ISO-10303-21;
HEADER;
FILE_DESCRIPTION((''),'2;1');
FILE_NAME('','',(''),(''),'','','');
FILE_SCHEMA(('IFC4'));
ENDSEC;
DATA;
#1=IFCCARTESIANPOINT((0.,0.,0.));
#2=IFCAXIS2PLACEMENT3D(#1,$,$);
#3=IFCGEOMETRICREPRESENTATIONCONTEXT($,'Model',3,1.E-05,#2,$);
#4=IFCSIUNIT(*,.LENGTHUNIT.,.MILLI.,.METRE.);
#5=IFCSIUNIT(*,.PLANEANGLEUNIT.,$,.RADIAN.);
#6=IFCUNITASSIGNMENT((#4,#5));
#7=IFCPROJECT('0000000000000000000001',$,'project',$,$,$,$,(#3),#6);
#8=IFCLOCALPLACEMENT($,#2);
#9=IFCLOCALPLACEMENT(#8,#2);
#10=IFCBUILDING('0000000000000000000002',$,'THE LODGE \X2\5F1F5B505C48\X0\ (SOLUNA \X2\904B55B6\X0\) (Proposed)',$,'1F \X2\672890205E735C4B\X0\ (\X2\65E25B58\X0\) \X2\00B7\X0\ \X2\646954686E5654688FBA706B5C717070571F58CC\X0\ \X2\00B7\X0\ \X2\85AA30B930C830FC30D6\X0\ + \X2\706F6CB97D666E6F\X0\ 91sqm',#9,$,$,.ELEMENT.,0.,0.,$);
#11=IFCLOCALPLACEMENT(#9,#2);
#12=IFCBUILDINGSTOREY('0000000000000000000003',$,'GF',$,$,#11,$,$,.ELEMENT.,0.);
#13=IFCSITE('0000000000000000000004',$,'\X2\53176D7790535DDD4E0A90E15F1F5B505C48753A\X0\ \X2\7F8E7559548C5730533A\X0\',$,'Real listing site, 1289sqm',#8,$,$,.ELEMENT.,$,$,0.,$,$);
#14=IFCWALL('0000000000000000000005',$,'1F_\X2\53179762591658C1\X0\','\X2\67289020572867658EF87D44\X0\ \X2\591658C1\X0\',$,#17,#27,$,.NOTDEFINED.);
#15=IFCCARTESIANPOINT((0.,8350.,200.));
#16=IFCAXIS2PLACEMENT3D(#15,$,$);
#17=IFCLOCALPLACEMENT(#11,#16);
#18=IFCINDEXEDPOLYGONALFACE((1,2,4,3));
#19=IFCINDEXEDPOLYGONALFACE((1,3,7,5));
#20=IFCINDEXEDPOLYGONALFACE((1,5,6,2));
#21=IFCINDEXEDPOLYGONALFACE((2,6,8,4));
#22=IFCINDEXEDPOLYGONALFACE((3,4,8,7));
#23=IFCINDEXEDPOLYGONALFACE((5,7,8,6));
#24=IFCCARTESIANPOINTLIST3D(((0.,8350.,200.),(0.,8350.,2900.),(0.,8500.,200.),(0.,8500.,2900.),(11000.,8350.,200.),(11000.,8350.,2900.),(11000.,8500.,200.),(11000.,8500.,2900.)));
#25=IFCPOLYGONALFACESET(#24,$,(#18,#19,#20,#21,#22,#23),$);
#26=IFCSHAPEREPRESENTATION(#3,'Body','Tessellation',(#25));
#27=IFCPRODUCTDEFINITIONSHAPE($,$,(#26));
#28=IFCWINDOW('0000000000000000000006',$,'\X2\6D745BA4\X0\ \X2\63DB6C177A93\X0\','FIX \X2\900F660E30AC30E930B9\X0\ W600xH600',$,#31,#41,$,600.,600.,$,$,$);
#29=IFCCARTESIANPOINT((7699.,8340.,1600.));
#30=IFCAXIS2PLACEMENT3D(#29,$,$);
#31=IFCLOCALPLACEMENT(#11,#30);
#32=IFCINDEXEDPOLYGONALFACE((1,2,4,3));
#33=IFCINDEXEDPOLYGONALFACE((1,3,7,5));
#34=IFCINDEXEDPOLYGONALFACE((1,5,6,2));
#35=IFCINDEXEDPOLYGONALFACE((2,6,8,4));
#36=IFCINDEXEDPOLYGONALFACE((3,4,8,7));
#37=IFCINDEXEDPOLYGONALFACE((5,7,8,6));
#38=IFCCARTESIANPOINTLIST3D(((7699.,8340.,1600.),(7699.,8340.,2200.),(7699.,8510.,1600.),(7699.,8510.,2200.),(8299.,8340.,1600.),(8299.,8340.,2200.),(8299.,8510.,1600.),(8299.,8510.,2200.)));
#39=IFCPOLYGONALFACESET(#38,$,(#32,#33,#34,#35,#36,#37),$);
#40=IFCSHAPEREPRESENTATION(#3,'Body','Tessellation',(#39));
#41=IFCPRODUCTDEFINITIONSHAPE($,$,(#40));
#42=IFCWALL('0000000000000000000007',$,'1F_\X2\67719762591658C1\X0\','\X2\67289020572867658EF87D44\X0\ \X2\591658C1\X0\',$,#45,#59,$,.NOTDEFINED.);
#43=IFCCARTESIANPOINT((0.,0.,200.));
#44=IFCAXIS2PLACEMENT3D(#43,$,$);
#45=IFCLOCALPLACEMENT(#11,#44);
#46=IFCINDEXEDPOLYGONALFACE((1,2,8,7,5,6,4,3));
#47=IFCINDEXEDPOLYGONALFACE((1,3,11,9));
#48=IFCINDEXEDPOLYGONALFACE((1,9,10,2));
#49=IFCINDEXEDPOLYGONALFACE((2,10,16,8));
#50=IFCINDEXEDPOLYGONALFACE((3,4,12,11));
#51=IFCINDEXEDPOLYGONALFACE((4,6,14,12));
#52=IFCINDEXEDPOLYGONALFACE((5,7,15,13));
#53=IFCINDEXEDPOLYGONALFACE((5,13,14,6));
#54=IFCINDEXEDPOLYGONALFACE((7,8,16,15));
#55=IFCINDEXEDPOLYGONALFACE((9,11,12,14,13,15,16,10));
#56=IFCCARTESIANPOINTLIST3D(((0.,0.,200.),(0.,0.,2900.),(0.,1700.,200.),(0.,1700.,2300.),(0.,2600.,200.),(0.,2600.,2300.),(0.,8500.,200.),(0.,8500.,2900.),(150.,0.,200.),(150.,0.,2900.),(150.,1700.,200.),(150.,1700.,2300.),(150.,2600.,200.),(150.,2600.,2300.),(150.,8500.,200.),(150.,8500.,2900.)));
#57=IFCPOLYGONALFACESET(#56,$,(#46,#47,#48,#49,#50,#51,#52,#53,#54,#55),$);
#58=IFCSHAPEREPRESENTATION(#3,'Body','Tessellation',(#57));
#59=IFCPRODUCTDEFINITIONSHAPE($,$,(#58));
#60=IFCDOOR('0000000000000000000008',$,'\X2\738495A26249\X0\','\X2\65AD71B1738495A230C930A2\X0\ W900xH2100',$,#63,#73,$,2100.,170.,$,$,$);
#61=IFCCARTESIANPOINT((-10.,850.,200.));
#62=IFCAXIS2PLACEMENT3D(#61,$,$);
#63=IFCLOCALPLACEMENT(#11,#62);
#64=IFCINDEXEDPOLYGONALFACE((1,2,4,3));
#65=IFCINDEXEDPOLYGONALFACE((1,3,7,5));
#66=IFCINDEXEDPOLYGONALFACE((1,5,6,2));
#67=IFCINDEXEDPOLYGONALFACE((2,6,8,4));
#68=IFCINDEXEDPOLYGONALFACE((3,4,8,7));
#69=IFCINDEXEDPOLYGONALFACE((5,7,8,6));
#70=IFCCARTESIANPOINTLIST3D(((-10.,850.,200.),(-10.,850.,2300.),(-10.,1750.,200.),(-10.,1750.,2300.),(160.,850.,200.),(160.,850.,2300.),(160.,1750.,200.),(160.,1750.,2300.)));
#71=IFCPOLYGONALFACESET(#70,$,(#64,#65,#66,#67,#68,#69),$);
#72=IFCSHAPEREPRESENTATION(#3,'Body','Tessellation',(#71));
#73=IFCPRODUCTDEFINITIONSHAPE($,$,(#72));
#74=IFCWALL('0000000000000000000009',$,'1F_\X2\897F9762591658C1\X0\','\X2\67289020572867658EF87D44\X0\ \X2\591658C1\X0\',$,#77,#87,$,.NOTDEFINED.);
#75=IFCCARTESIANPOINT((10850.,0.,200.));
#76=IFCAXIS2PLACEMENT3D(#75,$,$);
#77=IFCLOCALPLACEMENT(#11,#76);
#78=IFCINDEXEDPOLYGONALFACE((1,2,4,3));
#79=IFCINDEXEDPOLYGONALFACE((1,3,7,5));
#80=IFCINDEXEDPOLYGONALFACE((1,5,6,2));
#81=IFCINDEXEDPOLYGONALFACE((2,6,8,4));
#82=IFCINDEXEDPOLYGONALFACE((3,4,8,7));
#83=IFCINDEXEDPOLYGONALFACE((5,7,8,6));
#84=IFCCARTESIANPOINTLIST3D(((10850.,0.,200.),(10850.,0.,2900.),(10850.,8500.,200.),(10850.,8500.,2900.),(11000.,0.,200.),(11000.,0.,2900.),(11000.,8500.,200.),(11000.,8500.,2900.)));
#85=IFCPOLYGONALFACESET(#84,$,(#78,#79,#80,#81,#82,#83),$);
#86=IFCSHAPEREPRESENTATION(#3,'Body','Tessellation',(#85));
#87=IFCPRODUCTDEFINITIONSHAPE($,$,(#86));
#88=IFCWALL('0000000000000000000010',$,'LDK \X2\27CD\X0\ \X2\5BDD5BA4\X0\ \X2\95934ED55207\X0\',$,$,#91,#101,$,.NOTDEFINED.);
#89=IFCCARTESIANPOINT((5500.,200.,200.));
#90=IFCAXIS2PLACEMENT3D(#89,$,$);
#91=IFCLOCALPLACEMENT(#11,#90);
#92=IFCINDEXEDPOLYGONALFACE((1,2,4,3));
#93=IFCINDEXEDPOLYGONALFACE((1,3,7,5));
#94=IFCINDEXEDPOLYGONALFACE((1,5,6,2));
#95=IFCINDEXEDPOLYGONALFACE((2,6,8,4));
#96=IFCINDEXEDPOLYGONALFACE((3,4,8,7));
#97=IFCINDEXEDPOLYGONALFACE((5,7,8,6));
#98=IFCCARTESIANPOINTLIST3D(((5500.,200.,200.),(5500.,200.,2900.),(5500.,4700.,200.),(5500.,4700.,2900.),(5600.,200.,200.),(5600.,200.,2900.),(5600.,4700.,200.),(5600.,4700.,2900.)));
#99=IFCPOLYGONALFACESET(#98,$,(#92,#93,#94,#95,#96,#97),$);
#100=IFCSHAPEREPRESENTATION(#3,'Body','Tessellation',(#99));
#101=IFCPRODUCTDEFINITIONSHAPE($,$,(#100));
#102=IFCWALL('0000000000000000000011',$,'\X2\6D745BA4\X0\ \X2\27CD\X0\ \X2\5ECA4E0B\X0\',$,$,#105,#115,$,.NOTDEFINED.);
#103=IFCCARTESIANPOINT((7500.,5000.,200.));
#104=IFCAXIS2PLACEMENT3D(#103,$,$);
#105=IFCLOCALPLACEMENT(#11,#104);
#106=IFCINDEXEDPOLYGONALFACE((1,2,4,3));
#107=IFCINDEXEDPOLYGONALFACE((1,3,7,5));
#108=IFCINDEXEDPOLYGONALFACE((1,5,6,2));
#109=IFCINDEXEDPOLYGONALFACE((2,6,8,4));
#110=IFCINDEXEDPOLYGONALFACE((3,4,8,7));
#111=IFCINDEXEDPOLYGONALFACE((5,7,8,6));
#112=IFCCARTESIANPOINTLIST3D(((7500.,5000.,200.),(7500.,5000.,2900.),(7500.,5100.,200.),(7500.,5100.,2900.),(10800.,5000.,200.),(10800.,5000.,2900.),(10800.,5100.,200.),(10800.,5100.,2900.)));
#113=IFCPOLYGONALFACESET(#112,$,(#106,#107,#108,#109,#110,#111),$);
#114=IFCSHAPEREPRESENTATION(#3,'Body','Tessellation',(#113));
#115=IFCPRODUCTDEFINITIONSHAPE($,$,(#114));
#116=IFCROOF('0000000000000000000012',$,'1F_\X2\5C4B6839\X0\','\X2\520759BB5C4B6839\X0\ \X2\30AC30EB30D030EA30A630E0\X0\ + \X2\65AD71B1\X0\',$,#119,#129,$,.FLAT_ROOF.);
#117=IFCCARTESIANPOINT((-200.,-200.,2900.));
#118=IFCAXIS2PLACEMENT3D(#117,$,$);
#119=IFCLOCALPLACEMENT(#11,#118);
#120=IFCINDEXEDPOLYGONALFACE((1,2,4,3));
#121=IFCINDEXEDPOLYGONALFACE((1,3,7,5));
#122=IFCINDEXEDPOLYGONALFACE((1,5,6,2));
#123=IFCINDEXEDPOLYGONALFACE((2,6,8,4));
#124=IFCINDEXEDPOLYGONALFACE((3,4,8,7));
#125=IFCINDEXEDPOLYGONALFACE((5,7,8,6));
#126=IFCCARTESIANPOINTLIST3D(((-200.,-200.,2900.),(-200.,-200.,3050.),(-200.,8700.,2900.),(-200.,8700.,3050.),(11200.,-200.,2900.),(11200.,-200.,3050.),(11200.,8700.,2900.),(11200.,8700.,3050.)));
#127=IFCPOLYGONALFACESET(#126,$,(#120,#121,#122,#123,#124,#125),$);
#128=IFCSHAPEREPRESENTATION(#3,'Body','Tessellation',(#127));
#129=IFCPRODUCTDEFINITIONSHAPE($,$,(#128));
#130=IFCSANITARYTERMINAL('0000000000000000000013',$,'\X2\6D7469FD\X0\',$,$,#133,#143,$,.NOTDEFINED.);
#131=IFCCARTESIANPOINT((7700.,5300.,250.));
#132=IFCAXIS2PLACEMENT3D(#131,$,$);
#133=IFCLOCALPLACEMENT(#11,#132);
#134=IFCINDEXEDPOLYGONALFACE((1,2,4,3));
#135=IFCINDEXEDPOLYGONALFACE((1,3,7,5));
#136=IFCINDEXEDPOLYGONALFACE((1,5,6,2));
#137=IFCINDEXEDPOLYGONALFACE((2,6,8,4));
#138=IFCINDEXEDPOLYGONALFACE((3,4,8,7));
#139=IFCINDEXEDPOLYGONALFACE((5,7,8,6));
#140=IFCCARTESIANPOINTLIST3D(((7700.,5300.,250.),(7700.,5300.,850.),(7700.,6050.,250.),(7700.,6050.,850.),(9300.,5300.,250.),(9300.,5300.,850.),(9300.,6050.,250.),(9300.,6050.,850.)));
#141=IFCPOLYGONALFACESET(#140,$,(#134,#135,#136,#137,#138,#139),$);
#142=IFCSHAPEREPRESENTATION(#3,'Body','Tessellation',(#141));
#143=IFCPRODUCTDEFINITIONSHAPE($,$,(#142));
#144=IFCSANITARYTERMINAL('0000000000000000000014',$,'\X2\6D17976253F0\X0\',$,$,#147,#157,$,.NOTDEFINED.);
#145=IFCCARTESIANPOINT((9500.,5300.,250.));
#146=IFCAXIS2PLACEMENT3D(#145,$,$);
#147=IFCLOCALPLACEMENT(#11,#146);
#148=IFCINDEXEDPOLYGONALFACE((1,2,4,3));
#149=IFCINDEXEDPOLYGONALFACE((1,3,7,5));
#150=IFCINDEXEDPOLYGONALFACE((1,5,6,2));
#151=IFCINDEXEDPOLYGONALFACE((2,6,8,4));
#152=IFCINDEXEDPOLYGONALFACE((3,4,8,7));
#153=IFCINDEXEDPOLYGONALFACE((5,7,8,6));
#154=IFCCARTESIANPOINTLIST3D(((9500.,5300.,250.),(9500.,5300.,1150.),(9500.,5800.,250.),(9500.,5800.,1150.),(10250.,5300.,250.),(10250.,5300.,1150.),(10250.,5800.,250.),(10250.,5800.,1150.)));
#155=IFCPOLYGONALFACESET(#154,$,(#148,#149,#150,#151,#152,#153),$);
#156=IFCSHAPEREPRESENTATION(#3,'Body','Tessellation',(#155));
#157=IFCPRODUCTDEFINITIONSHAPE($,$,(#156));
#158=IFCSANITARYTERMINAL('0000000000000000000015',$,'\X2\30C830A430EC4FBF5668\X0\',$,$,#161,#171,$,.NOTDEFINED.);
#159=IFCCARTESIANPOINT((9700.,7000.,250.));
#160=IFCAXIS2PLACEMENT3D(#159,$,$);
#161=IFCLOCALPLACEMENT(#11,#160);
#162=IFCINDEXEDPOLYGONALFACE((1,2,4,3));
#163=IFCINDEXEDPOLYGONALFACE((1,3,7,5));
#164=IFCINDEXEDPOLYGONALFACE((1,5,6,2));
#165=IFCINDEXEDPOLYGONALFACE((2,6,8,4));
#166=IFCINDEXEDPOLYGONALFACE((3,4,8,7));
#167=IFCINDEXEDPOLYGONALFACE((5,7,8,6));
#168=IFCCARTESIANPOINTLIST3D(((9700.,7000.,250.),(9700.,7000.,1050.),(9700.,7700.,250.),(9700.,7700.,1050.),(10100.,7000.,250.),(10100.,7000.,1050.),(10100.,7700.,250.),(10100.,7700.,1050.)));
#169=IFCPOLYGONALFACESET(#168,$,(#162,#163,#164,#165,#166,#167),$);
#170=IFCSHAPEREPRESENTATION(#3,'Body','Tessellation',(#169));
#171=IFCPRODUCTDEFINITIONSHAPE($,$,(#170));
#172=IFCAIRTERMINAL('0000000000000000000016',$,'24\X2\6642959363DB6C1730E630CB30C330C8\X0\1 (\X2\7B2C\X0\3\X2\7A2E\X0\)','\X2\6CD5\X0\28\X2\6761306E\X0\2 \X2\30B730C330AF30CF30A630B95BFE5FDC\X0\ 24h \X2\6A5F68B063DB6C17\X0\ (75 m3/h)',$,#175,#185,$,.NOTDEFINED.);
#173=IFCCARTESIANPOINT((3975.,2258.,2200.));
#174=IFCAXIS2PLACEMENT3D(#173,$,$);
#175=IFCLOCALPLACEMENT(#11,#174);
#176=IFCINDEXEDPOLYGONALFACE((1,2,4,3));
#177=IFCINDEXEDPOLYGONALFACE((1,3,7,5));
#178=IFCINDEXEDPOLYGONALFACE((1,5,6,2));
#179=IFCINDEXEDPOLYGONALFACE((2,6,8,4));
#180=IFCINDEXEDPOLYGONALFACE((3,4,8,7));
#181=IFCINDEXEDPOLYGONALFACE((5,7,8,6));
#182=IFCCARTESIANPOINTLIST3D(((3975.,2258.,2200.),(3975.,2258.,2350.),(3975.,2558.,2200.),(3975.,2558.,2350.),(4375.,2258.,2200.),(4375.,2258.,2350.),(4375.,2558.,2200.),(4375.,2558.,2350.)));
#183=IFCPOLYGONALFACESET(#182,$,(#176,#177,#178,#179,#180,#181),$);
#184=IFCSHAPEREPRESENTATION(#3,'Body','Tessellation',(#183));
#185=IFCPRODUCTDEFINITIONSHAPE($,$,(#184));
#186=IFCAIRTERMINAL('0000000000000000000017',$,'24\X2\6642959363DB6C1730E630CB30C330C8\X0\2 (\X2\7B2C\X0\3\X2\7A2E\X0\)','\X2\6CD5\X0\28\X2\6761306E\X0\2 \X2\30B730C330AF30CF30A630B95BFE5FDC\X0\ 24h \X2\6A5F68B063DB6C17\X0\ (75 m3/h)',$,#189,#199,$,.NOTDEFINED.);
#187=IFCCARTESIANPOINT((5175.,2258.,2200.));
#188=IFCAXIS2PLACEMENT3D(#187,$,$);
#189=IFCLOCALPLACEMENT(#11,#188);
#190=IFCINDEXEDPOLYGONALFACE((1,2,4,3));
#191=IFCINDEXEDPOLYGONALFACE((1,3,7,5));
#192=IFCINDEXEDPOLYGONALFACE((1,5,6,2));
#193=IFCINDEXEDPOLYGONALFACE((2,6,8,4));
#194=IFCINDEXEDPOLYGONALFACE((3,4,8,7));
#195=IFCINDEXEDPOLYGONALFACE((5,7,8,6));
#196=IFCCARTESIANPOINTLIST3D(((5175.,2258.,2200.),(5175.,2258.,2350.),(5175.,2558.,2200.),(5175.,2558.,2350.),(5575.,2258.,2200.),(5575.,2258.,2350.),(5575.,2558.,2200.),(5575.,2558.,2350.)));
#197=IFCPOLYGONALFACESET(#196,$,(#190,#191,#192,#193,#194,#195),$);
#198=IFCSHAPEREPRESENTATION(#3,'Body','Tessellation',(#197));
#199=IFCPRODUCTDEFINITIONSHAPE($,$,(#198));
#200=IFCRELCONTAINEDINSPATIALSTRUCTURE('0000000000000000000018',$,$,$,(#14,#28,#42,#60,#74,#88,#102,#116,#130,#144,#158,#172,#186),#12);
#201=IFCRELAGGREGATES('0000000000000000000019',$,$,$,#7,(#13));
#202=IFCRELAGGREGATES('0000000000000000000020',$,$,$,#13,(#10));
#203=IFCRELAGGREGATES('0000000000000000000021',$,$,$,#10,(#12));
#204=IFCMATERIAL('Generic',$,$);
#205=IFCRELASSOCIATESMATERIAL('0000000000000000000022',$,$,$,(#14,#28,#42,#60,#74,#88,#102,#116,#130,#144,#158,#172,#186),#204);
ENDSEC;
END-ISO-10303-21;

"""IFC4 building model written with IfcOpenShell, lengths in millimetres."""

from ifc_helpers import new_model, si_unit, frame, frame_2d, origin, place, context, project, spatial, rectangle, extrude, material, element, fill, save


model = new_model("IFC4")

# Units and contexts
model_context = context("Model", 3, precision=1e-05, world=origin())
ifc_project = project(units=[si_unit("LENGTHUNIT", "METRE", prefix="MILLI"), si_unit("PLANEANGLEUNIT", "RADIAN")], contexts=[model_context])

# Site, building, storey
site_placement = place(None, origin())
site = spatial("IfcSite", under=ifc_project, at=site_placement, Name="北海道川上郡弟子屈町 美留和地区", ObjectType="Real listing site, 1289sqm", CompositionType="ELEMENT", RefElevation=0.0)
building_placement = place(site_placement, origin())
building = spatial("IfcBuilding", under=site, at=building_placement, Name="THE LODGE 弟子屈 (SOLUNA 運営) (Proposed)", ObjectType="1F 木造平屋 (既存) · 摩周湖周辺火山灰土壌 · 薪ストーブ + 灯油給湯 91sqm", CompositionType="ELEMENT", ElevationOfRefHeight=0.0, ElevationOfTerrain=0.0)
storey_placement = place(building_placement, origin())
storey = spatial("IfcBuildingStorey", under=building, at=storey_placement, Name="GF", CompositionType="ELEMENT", Elevation=0.0)

# Wall, opening, window
ifc_material_1 = material(Name="Generic")
wall_1_placement = place(storey_placement, frame((0.0, 8350.0, 200.0)))
wall_1 = element("IfcWall", 1, at=wall_1_placement, inside=storey, material=ifc_material_1, Name="1F_北面外壁", Description="木造在来軸組 外壁", PredefinedType="NOTDEFINED", context=model_context, shape_type="SweptSolid", body=[
    extrude(rectangle(XDim=11000.0, YDim=150.0, at=frame_2d((5500.0, 75.0))), frame((0.0, 8350.0, 200.0)), (0.0, 0.0, 1.0), 2700.0),
])
opening_1_placement = place(storey_placement, frame((7699.0, 8340.0, 1600.0)))
opening_1 = element("IfcOpeningElement", 2, at=opening_1_placement, cuts=wall_1, PredefinedType="NOTDEFINED", context=model_context, shape_type="SweptSolid", body=[
    extrude(rectangle(XDim=600.0, YDim=170.0, at=frame_2d((300.0, 85.0))), frame((7699.0, 8340.0, 1600.0)), (0.0, 0.0, 1.0), 600.0),
])
window_1_placement = place(storey_placement, frame((7699.0, 8340.0, 1600.0)))
window_1 = element("IfcWindow", 3, at=window_1_placement, inside=storey, material=ifc_material_1, Name="浴室 換気窓", Description="FIX 透明ガラス W600xH600", OverallHeight=600.0, OverallWidth=600.0, context=model_context, shape_type="SweptSolid", body=[
    extrude(rectangle(XDim=600.0, YDim=170.0, at=frame_2d((300.0, 85.0))), frame((7699.0, 8340.0, 1600.0)), (0.0, 0.0, 1.0), 600.0),
])
fill(opening_1, window_1)

# Wall, opening, door
wall_2_placement = place(storey_placement, frame((0.0, 0.0, 200.0)))
wall_2 = element("IfcWall", 4, at=wall_2_placement, inside=storey, material=ifc_material_1, Name="1F_東面外壁", Description="木造在来軸組 外壁", PredefinedType="NOTDEFINED", context=model_context, shape_type="SweptSolid", body=[
    extrude(rectangle(XDim=150.0, YDim=8500.0, at=frame_2d((75.0, 4250.0))), frame((0.0, 0.0, 200.0)), (0.0, 0.0, 1.0), 2700.0),
])
opening_2_placement = place(storey_placement, frame((-10.0, 850.0, 200.0)))
opening_2 = element("IfcOpeningElement", 5, at=opening_2_placement, cuts=wall_2, PredefinedType="NOTDEFINED", context=model_context, shape_type="SweptSolid", body=[
    extrude(rectangle(XDim=170.0, YDim=900.0, at=frame_2d((85.0, 450.0))), frame((-10.0, 850.0, 200.0)), (0.0, 0.0, 1.0), 2100.0),
])
door_placement = place(storey_placement, frame((-10.0, 850.0, 200.0)))
door = element("IfcDoor", 6, at=door_placement, inside=storey, material=ifc_material_1, Name="玄関扉", Description="断熱玄関ドア W900xH2100", OverallHeight=2100.0, OverallWidth=170.0, context=model_context, shape_type="SweptSolid", body=[
    extrude(rectangle(XDim=170.0, YDim=900.0, at=frame_2d((85.0, 450.0))), frame((-10.0, 850.0, 200.0)), (0.0, 0.0, 1.0), 2100.0),
])
fill(opening_2, door)

# Walls
wall_3_placement = place(storey_placement, frame((10850.0, 0.0, 200.0)))
element("IfcWall", 7, at=wall_3_placement, inside=storey, material=ifc_material_1, Name="1F_西面外壁", Description="木造在来軸組 外壁", PredefinedType="NOTDEFINED", context=model_context, shape_type="SweptSolid", body=[
    extrude(rectangle(XDim=150.0, YDim=8500.0, at=frame_2d((75.0, 4250.0))), frame((10850.0, 0.0, 200.0)), (0.0, 0.0, 1.0), 2700.0),
])
wall_4_placement = place(storey_placement, frame((5500.0, 200.0, 200.0)))
element("IfcWall", 8, at=wall_4_placement, inside=storey, material=ifc_material_1, Name="LDK ⟍ 寝室 間仕切", PredefinedType="NOTDEFINED", context=model_context, shape_type="SweptSolid", body=[
    extrude(rectangle(XDim=100.0, YDim=4500.0, at=frame_2d((50.0, 2250.0))), frame((5500.0, 200.0, 200.0)), (0.0, 0.0, 1.0), 2700.0),
])
wall_5_placement = place(storey_placement, frame((7500.0, 5000.0, 200.0)))
element("IfcWall", 9, at=wall_5_placement, inside=storey, material=ifc_material_1, Name="浴室 ⟍ 廊下", PredefinedType="NOTDEFINED", context=model_context, shape_type="SweptSolid", body=[
    extrude(rectangle(XDim=3300.0, YDim=100.0, at=frame_2d((1650.0, 50.0))), frame((7500.0, 5000.0, 200.0)), (0.0, 0.0, 1.0), 2700.0),
])

# Roof
roof_placement = place(storey_placement, frame((-200.0, -200.0, 2900.0)))
element("IfcRoof", 10, at=roof_placement, inside=storey, material=ifc_material_1, Name="1F_屋根", Description="切妻屋根 ガルバリウム + 断熱", PredefinedType="FLAT_ROOF", context=model_context, shape_type="SweptSolid", body=[
    extrude(rectangle(XDim=11400.0, YDim=8900.0, at=frame_2d((5700.0, 4450.0))), frame((-200.0, -200.0, 2900.0)), (0.0, 0.0, 1.0), 150.0),
])

# Sanitary terminals
sanitary_terminal_1_placement = place(storey_placement, frame((7700.0, 5300.0, 250.0)))
element("IfcSanitaryTerminal", 11, at=sanitary_terminal_1_placement, inside=storey, material=ifc_material_1, Name="浴槽", PredefinedType="NOTDEFINED", context=model_context, shape_type="SweptSolid", body=[
    extrude(rectangle(XDim=1600.0, YDim=750.0, at=frame_2d((800.0, 375.0))), frame((7700.0, 5300.0, 250.0)), (0.0, 0.0, 1.0), 600.0),
])
sanitary_terminal_2_placement = place(storey_placement, frame((9500.0, 5300.0, 250.0)))
element("IfcSanitaryTerminal", 12, at=sanitary_terminal_2_placement, inside=storey, material=ifc_material_1, Name="洗面台", PredefinedType="NOTDEFINED", context=model_context, shape_type="SweptSolid", body=[
    extrude(rectangle(XDim=750.0, YDim=500.0, at=frame_2d((375.0, 250.0))), frame((9500.0, 5300.0, 250.0)), (0.0, 0.0, 1.0), 900.0),
])
sanitary_terminal_3_placement = place(storey_placement, frame((9700.0, 7000.0, 250.0)))
element("IfcSanitaryTerminal", 13, at=sanitary_terminal_3_placement, inside=storey, material=ifc_material_1, Name="トイレ便器", PredefinedType="NOTDEFINED", context=model_context, shape_type="SweptSolid", body=[
    extrude(rectangle(XDim=400.0, YDim=700.0, at=frame_2d((200.0, 350.0))), frame((9700.0, 7000.0, 250.0)), (0.0, 0.0, 1.0), 800.0),
])

# Air terminals
air_terminal_1_placement = place(storey_placement, frame((3975.0, 2258.0, 2200.0)))
element("IfcAirTerminal", 14, at=air_terminal_1_placement, inside=storey, material=ifc_material_1, Name="24時間換気ユニット1 (第3種)", Description="法28条の2 シックハウス対応 24h 機械換気 (75 m3/h)", PredefinedType="NOTDEFINED", context=model_context, shape_type="SweptSolid", body=[
    extrude(rectangle(XDim=400.0, YDim=300.0, at=frame_2d((200.0, 150.0))), frame((3975.0, 2258.0, 2200.0)), (0.0, 0.0, 1.0), 150.0),
])
air_terminal_2_placement = place(storey_placement, frame((5175.0, 2258.0, 2200.0)))
element("IfcAirTerminal", 15, at=air_terminal_2_placement, inside=storey, material=ifc_material_1, Name="24時間換気ユニット2 (第3種)", Description="法28条の2 シックハウス対応 24h 機械換気 (75 m3/h)", PredefinedType="NOTDEFINED", context=model_context, shape_type="SweptSolid", body=[
    extrude(rectangle(XDim=400.0, YDim=300.0, at=frame_2d((200.0, 150.0))), frame((5175.0, 2258.0, 2200.0)), (0.0, 0.0, 1.0), 150.0),
])

save(model, "model.ifc")
